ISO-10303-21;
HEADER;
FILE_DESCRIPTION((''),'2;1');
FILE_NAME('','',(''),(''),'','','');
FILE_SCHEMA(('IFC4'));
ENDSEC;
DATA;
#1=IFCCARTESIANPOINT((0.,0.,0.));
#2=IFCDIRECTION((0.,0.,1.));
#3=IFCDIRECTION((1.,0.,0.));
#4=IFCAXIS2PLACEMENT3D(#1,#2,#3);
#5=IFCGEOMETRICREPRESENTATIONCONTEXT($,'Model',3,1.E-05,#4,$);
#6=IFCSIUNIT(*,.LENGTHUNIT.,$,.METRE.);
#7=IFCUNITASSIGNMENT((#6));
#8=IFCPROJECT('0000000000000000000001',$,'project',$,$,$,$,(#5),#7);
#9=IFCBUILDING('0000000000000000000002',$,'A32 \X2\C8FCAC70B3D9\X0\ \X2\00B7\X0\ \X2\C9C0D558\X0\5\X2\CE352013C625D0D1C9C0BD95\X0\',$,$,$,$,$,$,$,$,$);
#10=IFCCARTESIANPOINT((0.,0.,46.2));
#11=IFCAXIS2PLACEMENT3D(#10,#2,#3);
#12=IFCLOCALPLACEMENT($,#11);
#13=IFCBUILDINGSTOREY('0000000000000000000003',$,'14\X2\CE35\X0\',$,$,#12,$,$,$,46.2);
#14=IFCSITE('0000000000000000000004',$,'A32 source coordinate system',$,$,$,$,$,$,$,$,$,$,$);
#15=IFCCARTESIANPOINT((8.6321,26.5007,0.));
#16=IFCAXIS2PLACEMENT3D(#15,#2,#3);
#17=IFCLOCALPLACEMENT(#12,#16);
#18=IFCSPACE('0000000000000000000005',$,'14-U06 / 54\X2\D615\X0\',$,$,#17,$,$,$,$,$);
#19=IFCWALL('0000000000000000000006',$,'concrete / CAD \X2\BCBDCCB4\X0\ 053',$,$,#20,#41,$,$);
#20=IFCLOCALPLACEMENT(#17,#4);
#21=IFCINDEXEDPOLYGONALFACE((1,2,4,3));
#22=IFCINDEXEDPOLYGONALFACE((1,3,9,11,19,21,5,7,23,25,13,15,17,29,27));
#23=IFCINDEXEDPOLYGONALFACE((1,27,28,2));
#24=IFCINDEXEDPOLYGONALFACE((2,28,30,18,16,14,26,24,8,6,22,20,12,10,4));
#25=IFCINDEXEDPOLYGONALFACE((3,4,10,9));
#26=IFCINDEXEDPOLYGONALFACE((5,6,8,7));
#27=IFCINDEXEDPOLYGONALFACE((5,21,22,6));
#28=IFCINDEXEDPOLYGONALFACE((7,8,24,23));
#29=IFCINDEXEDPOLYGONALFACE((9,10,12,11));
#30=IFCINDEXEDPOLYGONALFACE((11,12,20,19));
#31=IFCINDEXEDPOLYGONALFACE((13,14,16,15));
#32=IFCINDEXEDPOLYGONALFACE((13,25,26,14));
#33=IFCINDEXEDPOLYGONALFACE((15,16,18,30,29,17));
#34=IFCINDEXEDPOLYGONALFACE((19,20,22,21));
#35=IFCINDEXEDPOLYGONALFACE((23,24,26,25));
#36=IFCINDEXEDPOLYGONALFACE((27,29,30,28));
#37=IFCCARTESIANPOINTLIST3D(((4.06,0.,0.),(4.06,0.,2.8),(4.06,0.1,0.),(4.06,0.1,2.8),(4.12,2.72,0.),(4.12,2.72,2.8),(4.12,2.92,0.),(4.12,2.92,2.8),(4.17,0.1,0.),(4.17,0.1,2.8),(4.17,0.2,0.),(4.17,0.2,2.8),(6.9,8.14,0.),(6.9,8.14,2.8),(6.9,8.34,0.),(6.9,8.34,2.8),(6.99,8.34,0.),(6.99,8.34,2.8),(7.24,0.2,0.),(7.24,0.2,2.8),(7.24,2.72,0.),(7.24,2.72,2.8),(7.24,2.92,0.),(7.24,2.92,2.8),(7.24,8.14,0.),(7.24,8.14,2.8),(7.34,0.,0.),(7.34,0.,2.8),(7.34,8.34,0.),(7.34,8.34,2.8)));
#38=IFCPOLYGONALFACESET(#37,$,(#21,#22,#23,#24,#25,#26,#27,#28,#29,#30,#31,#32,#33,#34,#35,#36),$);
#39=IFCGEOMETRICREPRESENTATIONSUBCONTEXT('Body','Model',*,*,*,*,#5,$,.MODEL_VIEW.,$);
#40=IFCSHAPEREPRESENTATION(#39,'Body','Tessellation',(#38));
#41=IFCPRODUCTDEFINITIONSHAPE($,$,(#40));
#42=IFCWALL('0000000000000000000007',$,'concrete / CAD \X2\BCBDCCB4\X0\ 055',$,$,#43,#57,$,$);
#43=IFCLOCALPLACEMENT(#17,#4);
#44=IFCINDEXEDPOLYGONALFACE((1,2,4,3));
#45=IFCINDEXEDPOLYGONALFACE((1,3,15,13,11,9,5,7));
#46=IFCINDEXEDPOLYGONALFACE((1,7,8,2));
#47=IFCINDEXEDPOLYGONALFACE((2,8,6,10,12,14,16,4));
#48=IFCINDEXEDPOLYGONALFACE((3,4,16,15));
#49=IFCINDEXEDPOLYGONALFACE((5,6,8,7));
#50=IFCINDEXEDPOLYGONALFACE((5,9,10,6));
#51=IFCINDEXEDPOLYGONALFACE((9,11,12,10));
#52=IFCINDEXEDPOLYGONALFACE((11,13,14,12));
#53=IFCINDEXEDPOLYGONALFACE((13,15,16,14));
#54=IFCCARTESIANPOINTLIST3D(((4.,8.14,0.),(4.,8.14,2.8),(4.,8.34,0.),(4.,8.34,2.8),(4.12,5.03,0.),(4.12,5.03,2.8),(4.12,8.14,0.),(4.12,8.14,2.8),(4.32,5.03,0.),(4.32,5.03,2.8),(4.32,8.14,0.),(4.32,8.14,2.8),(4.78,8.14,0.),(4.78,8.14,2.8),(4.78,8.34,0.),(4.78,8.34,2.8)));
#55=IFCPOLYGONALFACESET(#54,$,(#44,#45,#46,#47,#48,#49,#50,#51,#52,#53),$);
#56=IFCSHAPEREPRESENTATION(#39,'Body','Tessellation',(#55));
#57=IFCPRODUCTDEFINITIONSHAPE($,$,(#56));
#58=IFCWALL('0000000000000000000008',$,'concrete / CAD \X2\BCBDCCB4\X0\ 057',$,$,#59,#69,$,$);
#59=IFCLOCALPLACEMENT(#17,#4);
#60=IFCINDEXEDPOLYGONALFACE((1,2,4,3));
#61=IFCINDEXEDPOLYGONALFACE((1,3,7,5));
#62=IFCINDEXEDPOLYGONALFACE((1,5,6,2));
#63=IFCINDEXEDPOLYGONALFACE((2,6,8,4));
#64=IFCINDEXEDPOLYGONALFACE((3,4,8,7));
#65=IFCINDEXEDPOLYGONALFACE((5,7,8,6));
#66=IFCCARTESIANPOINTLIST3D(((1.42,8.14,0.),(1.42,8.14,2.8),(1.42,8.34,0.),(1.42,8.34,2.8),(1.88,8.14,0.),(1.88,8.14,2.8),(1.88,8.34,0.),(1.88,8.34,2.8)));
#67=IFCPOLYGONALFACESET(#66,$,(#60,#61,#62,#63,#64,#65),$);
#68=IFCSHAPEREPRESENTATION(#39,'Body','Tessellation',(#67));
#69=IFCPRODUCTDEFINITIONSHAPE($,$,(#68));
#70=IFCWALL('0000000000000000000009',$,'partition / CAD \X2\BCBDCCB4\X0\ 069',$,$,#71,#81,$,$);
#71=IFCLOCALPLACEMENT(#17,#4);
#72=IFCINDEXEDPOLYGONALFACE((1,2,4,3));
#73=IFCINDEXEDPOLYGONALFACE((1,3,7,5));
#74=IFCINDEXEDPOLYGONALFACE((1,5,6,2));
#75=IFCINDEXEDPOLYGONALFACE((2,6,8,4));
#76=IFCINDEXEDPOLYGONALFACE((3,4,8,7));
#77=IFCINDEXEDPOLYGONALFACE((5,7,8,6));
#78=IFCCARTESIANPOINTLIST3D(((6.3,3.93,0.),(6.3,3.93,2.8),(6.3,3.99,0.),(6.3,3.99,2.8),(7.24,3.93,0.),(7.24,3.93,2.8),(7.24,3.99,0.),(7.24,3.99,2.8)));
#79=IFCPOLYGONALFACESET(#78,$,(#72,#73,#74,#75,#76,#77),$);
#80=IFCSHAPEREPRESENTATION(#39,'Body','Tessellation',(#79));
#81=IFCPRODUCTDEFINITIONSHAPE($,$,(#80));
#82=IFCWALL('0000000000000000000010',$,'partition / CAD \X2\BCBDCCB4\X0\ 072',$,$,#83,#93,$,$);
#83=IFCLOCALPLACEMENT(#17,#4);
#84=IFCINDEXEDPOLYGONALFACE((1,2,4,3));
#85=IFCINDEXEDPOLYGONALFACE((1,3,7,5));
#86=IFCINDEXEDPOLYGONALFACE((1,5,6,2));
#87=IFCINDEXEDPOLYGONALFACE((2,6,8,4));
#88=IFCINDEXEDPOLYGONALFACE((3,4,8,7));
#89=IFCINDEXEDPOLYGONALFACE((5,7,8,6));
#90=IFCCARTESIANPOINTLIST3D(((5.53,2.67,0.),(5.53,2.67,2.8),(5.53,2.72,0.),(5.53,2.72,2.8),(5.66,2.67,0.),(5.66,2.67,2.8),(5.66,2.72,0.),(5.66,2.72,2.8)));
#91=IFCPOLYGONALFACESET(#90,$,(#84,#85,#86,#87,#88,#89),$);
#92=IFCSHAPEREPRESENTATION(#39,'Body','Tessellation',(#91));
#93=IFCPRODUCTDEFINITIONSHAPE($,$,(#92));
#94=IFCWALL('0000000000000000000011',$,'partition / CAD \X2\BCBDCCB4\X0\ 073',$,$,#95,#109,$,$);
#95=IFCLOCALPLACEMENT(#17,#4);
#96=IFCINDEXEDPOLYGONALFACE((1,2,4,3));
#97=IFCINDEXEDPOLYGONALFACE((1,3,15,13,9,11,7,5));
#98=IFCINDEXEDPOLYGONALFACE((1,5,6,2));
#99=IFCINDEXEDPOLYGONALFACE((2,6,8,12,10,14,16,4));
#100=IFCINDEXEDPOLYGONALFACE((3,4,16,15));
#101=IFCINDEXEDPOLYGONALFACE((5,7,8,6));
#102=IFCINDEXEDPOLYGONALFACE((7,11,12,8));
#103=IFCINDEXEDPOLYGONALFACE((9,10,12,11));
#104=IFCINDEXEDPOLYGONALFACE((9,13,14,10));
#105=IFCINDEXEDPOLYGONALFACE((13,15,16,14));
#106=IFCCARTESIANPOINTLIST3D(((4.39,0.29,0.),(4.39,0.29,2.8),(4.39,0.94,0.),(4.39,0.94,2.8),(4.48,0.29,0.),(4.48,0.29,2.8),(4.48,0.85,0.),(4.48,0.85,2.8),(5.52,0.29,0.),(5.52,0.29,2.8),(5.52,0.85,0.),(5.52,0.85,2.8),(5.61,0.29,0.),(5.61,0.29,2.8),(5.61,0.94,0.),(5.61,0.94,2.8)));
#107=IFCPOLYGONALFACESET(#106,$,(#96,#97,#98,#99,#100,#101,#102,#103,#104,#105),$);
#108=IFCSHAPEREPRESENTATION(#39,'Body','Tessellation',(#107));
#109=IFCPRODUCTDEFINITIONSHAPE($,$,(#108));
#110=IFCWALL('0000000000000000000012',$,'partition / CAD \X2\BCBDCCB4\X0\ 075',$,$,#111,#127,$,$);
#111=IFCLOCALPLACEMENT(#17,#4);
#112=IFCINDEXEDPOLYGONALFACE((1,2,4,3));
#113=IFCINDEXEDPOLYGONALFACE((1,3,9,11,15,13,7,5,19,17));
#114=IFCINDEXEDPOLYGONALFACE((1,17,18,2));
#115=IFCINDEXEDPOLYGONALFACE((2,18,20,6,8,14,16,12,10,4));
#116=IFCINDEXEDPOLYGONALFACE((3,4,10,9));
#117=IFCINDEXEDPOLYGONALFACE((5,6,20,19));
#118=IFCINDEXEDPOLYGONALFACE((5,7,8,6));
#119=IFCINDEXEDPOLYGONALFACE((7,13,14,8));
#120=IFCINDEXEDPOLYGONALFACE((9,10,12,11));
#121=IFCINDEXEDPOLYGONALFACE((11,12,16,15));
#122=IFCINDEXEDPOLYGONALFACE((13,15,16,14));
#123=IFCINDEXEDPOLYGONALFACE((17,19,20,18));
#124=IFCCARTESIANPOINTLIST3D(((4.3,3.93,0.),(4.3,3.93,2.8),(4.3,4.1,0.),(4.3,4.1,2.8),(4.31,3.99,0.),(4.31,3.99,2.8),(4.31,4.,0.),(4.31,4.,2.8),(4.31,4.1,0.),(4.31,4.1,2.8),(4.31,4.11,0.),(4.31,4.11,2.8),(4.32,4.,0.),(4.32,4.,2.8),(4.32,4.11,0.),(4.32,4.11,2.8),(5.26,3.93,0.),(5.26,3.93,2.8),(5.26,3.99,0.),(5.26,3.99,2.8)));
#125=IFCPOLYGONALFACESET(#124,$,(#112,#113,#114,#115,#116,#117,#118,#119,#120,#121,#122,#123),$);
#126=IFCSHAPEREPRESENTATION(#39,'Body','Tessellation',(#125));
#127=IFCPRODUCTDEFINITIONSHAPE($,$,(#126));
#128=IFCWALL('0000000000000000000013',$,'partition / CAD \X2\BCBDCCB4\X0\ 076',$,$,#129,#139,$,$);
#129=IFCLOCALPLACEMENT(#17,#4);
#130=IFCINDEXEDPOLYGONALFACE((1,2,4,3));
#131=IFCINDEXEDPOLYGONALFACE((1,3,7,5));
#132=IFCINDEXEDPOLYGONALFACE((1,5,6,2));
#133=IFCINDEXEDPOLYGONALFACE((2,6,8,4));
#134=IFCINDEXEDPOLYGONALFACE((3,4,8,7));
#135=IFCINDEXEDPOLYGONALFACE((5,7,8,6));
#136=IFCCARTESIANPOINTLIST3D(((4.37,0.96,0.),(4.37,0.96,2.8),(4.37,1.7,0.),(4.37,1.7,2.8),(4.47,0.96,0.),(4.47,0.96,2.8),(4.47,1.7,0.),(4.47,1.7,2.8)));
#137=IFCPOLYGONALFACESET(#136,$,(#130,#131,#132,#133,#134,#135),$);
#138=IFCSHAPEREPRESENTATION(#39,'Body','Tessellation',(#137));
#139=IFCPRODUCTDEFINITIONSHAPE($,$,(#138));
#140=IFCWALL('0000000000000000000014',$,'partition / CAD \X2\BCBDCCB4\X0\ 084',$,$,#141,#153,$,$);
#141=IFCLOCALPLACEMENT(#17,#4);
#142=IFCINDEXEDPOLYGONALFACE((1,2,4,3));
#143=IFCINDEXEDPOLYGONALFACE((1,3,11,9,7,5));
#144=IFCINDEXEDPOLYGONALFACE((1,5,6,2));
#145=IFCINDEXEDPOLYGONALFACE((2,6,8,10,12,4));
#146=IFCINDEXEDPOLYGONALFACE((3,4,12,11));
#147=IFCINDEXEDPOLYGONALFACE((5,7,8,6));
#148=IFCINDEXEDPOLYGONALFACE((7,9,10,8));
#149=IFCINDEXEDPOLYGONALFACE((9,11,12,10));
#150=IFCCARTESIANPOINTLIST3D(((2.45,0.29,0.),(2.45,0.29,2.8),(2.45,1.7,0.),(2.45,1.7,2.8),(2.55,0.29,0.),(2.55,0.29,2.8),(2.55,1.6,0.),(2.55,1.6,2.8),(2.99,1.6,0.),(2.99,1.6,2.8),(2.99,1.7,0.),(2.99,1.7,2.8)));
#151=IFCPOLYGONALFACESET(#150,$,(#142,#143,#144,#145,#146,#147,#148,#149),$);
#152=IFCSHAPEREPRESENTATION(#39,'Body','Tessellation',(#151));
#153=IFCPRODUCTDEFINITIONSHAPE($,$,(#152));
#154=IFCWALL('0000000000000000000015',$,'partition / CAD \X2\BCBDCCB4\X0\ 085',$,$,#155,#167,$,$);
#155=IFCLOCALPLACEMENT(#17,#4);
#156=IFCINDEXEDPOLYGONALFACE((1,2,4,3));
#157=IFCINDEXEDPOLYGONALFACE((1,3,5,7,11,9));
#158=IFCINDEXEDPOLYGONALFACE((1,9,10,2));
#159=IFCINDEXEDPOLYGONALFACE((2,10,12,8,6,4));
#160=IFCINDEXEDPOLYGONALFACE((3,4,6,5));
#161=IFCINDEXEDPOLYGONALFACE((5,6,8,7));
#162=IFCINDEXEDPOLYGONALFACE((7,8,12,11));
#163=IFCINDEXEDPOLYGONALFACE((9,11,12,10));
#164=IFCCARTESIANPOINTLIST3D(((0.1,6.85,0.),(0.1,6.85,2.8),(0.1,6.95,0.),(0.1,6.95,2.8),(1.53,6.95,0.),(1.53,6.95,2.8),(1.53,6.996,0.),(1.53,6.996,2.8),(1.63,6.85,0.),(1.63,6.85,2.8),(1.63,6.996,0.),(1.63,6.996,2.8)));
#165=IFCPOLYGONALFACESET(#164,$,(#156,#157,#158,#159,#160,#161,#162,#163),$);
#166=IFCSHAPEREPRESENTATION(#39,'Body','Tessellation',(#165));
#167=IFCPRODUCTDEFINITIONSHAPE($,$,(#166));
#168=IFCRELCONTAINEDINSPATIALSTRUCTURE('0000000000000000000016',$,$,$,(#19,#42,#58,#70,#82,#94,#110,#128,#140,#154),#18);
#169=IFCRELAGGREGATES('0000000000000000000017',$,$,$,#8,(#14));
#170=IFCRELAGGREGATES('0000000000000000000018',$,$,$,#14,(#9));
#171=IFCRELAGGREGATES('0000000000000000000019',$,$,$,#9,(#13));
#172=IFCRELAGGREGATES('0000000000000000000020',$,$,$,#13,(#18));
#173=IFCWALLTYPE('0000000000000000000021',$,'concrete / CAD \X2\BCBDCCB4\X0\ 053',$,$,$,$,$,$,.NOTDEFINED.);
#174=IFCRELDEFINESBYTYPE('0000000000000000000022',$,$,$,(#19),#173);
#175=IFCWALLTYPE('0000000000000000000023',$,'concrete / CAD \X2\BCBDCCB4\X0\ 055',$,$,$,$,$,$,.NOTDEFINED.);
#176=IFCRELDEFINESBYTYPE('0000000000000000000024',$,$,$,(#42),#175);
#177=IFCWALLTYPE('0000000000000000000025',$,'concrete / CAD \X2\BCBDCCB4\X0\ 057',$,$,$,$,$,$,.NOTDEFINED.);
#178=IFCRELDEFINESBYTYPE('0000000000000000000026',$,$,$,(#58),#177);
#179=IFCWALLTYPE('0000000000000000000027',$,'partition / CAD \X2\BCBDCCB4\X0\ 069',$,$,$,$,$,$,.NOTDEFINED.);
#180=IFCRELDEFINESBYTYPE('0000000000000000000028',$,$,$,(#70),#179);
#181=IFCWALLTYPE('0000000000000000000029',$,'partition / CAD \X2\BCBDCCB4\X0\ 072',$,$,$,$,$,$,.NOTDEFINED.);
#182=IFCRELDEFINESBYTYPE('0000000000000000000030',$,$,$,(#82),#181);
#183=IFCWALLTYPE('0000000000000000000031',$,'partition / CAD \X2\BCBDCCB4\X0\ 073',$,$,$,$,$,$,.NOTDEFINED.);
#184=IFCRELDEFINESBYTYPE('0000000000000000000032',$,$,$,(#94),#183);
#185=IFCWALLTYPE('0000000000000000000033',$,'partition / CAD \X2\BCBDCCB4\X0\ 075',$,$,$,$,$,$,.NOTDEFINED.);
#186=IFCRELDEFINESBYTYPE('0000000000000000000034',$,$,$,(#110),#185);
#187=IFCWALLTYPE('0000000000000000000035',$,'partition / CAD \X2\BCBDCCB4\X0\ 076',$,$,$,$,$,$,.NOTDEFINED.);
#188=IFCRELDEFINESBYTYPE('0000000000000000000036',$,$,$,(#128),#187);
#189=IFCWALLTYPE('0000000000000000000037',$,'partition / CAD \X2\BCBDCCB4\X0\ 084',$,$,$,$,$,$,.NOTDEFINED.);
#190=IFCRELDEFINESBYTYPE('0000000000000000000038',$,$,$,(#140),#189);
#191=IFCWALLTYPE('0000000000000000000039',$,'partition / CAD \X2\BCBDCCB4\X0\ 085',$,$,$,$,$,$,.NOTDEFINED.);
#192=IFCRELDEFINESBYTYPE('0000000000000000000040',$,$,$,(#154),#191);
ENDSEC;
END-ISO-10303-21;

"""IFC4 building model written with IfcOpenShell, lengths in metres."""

from ifc_helpers import new_model, si_unit, frame, origin, origin_with_axes, place, context, subcontext, project, spatial, polyline, outline, extrude, source, transform, mapped, type_object, type_shapes, element, save


model = new_model("IFC4")

# Units and contexts
model_context = context("Model", 3, precision=1e-05, world=origin_with_axes())
body_context = subcontext(model_context, "Body", "Model", "MODEL_VIEW")
ifc_project = project(units=[si_unit("LENGTHUNIT", "METRE")], contexts=[model_context])

# Site, building, storey, space
site = spatial("IfcSite", under=ifc_project, Name="A32 source coordinate system")
building = spatial("IfcBuilding", under=site, Name="A32 주거동 · 지하5층–옥탑지붕")
storey_placement = place(None, frame((0.0, 0.0, 46.2), z_axis=(0.0, 0.0, 1.0), x_axis=(1.0, 0.0, 0.0)))
storey = spatial("IfcBuildingStorey", under=building, at=storey_placement, Name="14층", Elevation=46.2)
space_placement = place(storey_placement, frame((8.6321, 26.5007, 0.0), z_axis=(0.0, 0.0, 1.0), x_axis=(1.0, 0.0, 0.0)))
space = spatial("IfcSpace", under=storey, at=space_placement, Name="14-U06 / 54형")

# Walls
wall_type_1 = type_object("IfcWallType", Name="concrete / CAD 벽체 053", PredefinedType="NOTDEFINED")
shared_shape_1 = source(origin(), body_context, "Body", "SweptSolid", [
    extrude(outline(polyline([(7.24, 8.14), (6.9, 8.14), (6.9, 8.34), (6.99, 8.34), (6.99, 8.34), (7.34, 8.34), (7.34, 8.34), (7.34, 0.0), (4.06, 0.0), (4.06, 0.1), (4.17, 0.1), (4.17, 0.2), (7.24, 0.2), (7.24, 2.72), (4.12, 2.72), (4.12, 2.92), (7.24, 2.92), (7.24, 8.14)])), origin(), (0.0, 0.0, 1.0), 2.8),
])
type_shapes(wall_type_1, [shared_shape_1])
wall_1_placement = place(space_placement, origin_with_axes())
element("IfcWall", 1, at=wall_1_placement, inside=space, type_object=wall_type_1, Name="concrete / CAD 벽체 053", context=body_context, shape_type="MappedRepresentation", body=[
    mapped(shared_shape_1, transform((0.0, 0.0, 0.0), scale=1.0)),
])
wall_type_2 = type_object("IfcWallType", Name="concrete / CAD 벽체 055", PredefinedType="NOTDEFINED")
shared_shape_2 = source(origin(), body_context, "Body", "SweptSolid", [
    extrude(outline(polyline([(4.32, 5.03), (4.12, 5.03), (4.12, 8.14), (4.0, 8.14), (4.0, 8.34), (4.78, 8.34), (4.78, 8.14), (4.32, 8.14), (4.32, 5.03)])), origin(), (0.0, 0.0, 1.0), 2.8),
])
type_shapes(wall_type_2, [shared_shape_2])
wall_2_placement = place(space_placement, origin_with_axes())
element("IfcWall", 2, at=wall_2_placement, inside=space, type_object=wall_type_2, Name="concrete / CAD 벽체 055", context=body_context, shape_type="MappedRepresentation", body=[
    mapped(shared_shape_2, transform((0.0, 0.0, 0.0), scale=1.0)),
])
wall_type_3 = type_object("IfcWallType", Name="concrete / CAD 벽체 057", PredefinedType="NOTDEFINED")
shared_shape_3 = source(origin(), body_context, "Body", "SweptSolid", [
    extrude(outline(polyline([(1.42, 8.14), (1.42, 8.34), (1.88, 8.34), (1.88, 8.14), (1.42, 8.14)])), origin(), (0.0, 0.0, 1.0), 2.8),
])
type_shapes(wall_type_3, [shared_shape_3])
wall_3_placement = place(space_placement, origin_with_axes())
element("IfcWall", 3, at=wall_3_placement, inside=space, type_object=wall_type_3, Name="concrete / CAD 벽체 057", context=body_context, shape_type="MappedRepresentation", body=[
    mapped(shared_shape_3, transform((0.0, 0.0, 0.0), scale=1.0)),
])
wall_type_4 = type_object("IfcWallType", Name="partition / CAD 벽체 069", PredefinedType="NOTDEFINED")
shared_shape_4 = source(origin(), body_context, "Body", "SweptSolid", [
    extrude(outline(polyline([(7.24, 3.93), (6.3, 3.93), (6.3, 3.99), (7.24, 3.99), (7.24, 3.93)])), origin(), (0.0, 0.0, 1.0), 2.8),
])
type_shapes(wall_type_4, [shared_shape_4])
wall_4_placement = place(space_placement, origin_with_axes())
element("IfcWall", 4, at=wall_4_placement, inside=space, type_object=wall_type_4, Name="partition / CAD 벽체 069", context=body_context, shape_type="MappedRepresentation", body=[
    mapped(shared_shape_4, transform((0.0, 0.0, 0.0), scale=1.0)),
])
wall_type_5 = type_object("IfcWallType", Name="partition / CAD 벽체 072", PredefinedType="NOTDEFINED")
shared_shape_5 = source(origin(), body_context, "Body", "SweptSolid", [
    extrude(outline(polyline([(5.66, 2.67), (5.53, 2.67), (5.53, 2.72), (5.66, 2.72), (5.66, 2.67)])), origin(), (0.0, 0.0, 1.0), 2.8),
])
type_shapes(wall_type_5, [shared_shape_5])
wall_5_placement = place(space_placement, origin_with_axes())
element("IfcWall", 5, at=wall_5_placement, inside=space, type_object=wall_type_5, Name="partition / CAD 벽체 072", context=body_context, shape_type="MappedRepresentation", body=[
    mapped(shared_shape_5, transform((0.0, 0.0, 0.0), scale=1.0)),
])
wall_type_6 = type_object("IfcWallType", Name="partition / CAD 벽체 073", PredefinedType="NOTDEFINED")
shared_shape_6 = source(origin(), body_context, "Body", "SweptSolid", [
    extrude(outline(polyline([(4.48, 0.29), (4.39, 0.29), (4.39, 0.94), (5.61, 0.94), (5.61, 0.29), (5.52, 0.29), (5.52, 0.85), (4.48, 0.85), (4.48, 0.29)])), origin(), (0.0, 0.0, 1.0), 2.8),
])
type_shapes(wall_type_6, [shared_shape_6])
wall_6_placement = place(space_placement, origin_with_axes())
element("IfcWall", 6, at=wall_6_placement, inside=space, type_object=wall_type_6, Name="partition / CAD 벽체 073", context=body_context, shape_type="MappedRepresentation", body=[
    mapped(shared_shape_6, transform((0.0, 0.0, 0.0), scale=1.0)),
])
wall_type_7 = type_object("IfcWallType", Name="partition / CAD 벽체 075", PredefinedType="NOTDEFINED")
shared_shape_7 = source(origin(), body_context, "Body", "SweptSolid", [
    extrude(outline(polyline([(4.32, 4.0), (4.31, 4.0), (4.31, 3.99), (5.26, 3.99), (5.26, 3.93), (4.3, 3.93), (4.3, 4.1), (4.31, 4.1), (4.31, 4.11), (4.32, 4.11), (4.32, 4.0)])), origin(), (0.0, 0.0, 1.0), 2.8),
])
type_shapes(wall_type_7, [shared_shape_7])
wall_7_placement = place(space_placement, origin_with_axes())
element("IfcWall", 7, at=wall_7_placement, inside=space, type_object=wall_type_7, Name="partition / CAD 벽체 075", context=body_context, shape_type="MappedRepresentation", body=[
    mapped(shared_shape_7, transform((0.0, 0.0, 0.0), scale=1.0)),
])
wall_type_8 = type_object("IfcWallType", Name="partition / CAD 벽체 076", PredefinedType="NOTDEFINED")
shared_shape_8 = source(origin(), body_context, "Body", "SweptSolid", [
    extrude(outline(polyline([(4.37, 1.7), (4.47, 1.7), (4.47, 0.96), (4.37, 0.96), (4.37, 1.7)])), origin(), (0.0, 0.0, 1.0), 2.8),
])
type_shapes(wall_type_8, [shared_shape_8])
wall_8_placement = place(space_placement, origin_with_axes())
element("IfcWall", 8, at=wall_8_placement, inside=space, type_object=wall_type_8, Name="partition / CAD 벽체 076", context=body_context, shape_type="MappedRepresentation", body=[
    mapped(shared_shape_8, transform((0.0, 0.0, 0.0), scale=1.0)),
])
wall_type_9 = type_object("IfcWallType", Name="partition / CAD 벽체 084", PredefinedType="NOTDEFINED")
shared_shape_9 = source(origin(), body_context, "Body", "SweptSolid", [
    extrude(outline(polyline([(2.99, 1.6), (2.55, 1.6), (2.55, 0.29), (2.45, 0.29), (2.45, 1.7), (2.99, 1.7), (2.99, 1.6)])), origin(), (0.0, 0.0, 1.0), 2.8),
])
type_shapes(wall_type_9, [shared_shape_9])
wall_9_placement = place(space_placement, origin_with_axes())
element("IfcWall", 9, at=wall_9_placement, inside=space, type_object=wall_type_9, Name="partition / CAD 벽체 084", context=body_context, shape_type="MappedRepresentation", body=[
    mapped(shared_shape_9, transform((0.0, 0.0, 0.0), scale=1.0)),
])
wall_type_10 = type_object("IfcWallType", Name="partition / CAD 벽체 085", PredefinedType="NOTDEFINED")
shared_shape_10 = source(origin(), body_context, "Body", "SweptSolid", [
    extrude(outline(polyline([(1.63, 6.85), (0.1, 6.85), (0.1, 6.95), (1.53, 6.95), (1.53, 6.996), (1.63, 6.996), (1.63, 6.85)])), origin(), (0.0, 0.0, 1.0), 2.8),
])
type_shapes(wall_type_10, [shared_shape_10])
wall_10_placement = place(space_placement, origin_with_axes())
element("IfcWall", 10, at=wall_10_placement, inside=space, type_object=wall_type_10, Name="partition / CAD 벽체 085", context=body_context, shape_type="MappedRepresentation", body=[
    mapped(shared_shape_10, transform((0.0, 0.0, 0.0), scale=1.0)),
])

save(model, "model.ifc")
